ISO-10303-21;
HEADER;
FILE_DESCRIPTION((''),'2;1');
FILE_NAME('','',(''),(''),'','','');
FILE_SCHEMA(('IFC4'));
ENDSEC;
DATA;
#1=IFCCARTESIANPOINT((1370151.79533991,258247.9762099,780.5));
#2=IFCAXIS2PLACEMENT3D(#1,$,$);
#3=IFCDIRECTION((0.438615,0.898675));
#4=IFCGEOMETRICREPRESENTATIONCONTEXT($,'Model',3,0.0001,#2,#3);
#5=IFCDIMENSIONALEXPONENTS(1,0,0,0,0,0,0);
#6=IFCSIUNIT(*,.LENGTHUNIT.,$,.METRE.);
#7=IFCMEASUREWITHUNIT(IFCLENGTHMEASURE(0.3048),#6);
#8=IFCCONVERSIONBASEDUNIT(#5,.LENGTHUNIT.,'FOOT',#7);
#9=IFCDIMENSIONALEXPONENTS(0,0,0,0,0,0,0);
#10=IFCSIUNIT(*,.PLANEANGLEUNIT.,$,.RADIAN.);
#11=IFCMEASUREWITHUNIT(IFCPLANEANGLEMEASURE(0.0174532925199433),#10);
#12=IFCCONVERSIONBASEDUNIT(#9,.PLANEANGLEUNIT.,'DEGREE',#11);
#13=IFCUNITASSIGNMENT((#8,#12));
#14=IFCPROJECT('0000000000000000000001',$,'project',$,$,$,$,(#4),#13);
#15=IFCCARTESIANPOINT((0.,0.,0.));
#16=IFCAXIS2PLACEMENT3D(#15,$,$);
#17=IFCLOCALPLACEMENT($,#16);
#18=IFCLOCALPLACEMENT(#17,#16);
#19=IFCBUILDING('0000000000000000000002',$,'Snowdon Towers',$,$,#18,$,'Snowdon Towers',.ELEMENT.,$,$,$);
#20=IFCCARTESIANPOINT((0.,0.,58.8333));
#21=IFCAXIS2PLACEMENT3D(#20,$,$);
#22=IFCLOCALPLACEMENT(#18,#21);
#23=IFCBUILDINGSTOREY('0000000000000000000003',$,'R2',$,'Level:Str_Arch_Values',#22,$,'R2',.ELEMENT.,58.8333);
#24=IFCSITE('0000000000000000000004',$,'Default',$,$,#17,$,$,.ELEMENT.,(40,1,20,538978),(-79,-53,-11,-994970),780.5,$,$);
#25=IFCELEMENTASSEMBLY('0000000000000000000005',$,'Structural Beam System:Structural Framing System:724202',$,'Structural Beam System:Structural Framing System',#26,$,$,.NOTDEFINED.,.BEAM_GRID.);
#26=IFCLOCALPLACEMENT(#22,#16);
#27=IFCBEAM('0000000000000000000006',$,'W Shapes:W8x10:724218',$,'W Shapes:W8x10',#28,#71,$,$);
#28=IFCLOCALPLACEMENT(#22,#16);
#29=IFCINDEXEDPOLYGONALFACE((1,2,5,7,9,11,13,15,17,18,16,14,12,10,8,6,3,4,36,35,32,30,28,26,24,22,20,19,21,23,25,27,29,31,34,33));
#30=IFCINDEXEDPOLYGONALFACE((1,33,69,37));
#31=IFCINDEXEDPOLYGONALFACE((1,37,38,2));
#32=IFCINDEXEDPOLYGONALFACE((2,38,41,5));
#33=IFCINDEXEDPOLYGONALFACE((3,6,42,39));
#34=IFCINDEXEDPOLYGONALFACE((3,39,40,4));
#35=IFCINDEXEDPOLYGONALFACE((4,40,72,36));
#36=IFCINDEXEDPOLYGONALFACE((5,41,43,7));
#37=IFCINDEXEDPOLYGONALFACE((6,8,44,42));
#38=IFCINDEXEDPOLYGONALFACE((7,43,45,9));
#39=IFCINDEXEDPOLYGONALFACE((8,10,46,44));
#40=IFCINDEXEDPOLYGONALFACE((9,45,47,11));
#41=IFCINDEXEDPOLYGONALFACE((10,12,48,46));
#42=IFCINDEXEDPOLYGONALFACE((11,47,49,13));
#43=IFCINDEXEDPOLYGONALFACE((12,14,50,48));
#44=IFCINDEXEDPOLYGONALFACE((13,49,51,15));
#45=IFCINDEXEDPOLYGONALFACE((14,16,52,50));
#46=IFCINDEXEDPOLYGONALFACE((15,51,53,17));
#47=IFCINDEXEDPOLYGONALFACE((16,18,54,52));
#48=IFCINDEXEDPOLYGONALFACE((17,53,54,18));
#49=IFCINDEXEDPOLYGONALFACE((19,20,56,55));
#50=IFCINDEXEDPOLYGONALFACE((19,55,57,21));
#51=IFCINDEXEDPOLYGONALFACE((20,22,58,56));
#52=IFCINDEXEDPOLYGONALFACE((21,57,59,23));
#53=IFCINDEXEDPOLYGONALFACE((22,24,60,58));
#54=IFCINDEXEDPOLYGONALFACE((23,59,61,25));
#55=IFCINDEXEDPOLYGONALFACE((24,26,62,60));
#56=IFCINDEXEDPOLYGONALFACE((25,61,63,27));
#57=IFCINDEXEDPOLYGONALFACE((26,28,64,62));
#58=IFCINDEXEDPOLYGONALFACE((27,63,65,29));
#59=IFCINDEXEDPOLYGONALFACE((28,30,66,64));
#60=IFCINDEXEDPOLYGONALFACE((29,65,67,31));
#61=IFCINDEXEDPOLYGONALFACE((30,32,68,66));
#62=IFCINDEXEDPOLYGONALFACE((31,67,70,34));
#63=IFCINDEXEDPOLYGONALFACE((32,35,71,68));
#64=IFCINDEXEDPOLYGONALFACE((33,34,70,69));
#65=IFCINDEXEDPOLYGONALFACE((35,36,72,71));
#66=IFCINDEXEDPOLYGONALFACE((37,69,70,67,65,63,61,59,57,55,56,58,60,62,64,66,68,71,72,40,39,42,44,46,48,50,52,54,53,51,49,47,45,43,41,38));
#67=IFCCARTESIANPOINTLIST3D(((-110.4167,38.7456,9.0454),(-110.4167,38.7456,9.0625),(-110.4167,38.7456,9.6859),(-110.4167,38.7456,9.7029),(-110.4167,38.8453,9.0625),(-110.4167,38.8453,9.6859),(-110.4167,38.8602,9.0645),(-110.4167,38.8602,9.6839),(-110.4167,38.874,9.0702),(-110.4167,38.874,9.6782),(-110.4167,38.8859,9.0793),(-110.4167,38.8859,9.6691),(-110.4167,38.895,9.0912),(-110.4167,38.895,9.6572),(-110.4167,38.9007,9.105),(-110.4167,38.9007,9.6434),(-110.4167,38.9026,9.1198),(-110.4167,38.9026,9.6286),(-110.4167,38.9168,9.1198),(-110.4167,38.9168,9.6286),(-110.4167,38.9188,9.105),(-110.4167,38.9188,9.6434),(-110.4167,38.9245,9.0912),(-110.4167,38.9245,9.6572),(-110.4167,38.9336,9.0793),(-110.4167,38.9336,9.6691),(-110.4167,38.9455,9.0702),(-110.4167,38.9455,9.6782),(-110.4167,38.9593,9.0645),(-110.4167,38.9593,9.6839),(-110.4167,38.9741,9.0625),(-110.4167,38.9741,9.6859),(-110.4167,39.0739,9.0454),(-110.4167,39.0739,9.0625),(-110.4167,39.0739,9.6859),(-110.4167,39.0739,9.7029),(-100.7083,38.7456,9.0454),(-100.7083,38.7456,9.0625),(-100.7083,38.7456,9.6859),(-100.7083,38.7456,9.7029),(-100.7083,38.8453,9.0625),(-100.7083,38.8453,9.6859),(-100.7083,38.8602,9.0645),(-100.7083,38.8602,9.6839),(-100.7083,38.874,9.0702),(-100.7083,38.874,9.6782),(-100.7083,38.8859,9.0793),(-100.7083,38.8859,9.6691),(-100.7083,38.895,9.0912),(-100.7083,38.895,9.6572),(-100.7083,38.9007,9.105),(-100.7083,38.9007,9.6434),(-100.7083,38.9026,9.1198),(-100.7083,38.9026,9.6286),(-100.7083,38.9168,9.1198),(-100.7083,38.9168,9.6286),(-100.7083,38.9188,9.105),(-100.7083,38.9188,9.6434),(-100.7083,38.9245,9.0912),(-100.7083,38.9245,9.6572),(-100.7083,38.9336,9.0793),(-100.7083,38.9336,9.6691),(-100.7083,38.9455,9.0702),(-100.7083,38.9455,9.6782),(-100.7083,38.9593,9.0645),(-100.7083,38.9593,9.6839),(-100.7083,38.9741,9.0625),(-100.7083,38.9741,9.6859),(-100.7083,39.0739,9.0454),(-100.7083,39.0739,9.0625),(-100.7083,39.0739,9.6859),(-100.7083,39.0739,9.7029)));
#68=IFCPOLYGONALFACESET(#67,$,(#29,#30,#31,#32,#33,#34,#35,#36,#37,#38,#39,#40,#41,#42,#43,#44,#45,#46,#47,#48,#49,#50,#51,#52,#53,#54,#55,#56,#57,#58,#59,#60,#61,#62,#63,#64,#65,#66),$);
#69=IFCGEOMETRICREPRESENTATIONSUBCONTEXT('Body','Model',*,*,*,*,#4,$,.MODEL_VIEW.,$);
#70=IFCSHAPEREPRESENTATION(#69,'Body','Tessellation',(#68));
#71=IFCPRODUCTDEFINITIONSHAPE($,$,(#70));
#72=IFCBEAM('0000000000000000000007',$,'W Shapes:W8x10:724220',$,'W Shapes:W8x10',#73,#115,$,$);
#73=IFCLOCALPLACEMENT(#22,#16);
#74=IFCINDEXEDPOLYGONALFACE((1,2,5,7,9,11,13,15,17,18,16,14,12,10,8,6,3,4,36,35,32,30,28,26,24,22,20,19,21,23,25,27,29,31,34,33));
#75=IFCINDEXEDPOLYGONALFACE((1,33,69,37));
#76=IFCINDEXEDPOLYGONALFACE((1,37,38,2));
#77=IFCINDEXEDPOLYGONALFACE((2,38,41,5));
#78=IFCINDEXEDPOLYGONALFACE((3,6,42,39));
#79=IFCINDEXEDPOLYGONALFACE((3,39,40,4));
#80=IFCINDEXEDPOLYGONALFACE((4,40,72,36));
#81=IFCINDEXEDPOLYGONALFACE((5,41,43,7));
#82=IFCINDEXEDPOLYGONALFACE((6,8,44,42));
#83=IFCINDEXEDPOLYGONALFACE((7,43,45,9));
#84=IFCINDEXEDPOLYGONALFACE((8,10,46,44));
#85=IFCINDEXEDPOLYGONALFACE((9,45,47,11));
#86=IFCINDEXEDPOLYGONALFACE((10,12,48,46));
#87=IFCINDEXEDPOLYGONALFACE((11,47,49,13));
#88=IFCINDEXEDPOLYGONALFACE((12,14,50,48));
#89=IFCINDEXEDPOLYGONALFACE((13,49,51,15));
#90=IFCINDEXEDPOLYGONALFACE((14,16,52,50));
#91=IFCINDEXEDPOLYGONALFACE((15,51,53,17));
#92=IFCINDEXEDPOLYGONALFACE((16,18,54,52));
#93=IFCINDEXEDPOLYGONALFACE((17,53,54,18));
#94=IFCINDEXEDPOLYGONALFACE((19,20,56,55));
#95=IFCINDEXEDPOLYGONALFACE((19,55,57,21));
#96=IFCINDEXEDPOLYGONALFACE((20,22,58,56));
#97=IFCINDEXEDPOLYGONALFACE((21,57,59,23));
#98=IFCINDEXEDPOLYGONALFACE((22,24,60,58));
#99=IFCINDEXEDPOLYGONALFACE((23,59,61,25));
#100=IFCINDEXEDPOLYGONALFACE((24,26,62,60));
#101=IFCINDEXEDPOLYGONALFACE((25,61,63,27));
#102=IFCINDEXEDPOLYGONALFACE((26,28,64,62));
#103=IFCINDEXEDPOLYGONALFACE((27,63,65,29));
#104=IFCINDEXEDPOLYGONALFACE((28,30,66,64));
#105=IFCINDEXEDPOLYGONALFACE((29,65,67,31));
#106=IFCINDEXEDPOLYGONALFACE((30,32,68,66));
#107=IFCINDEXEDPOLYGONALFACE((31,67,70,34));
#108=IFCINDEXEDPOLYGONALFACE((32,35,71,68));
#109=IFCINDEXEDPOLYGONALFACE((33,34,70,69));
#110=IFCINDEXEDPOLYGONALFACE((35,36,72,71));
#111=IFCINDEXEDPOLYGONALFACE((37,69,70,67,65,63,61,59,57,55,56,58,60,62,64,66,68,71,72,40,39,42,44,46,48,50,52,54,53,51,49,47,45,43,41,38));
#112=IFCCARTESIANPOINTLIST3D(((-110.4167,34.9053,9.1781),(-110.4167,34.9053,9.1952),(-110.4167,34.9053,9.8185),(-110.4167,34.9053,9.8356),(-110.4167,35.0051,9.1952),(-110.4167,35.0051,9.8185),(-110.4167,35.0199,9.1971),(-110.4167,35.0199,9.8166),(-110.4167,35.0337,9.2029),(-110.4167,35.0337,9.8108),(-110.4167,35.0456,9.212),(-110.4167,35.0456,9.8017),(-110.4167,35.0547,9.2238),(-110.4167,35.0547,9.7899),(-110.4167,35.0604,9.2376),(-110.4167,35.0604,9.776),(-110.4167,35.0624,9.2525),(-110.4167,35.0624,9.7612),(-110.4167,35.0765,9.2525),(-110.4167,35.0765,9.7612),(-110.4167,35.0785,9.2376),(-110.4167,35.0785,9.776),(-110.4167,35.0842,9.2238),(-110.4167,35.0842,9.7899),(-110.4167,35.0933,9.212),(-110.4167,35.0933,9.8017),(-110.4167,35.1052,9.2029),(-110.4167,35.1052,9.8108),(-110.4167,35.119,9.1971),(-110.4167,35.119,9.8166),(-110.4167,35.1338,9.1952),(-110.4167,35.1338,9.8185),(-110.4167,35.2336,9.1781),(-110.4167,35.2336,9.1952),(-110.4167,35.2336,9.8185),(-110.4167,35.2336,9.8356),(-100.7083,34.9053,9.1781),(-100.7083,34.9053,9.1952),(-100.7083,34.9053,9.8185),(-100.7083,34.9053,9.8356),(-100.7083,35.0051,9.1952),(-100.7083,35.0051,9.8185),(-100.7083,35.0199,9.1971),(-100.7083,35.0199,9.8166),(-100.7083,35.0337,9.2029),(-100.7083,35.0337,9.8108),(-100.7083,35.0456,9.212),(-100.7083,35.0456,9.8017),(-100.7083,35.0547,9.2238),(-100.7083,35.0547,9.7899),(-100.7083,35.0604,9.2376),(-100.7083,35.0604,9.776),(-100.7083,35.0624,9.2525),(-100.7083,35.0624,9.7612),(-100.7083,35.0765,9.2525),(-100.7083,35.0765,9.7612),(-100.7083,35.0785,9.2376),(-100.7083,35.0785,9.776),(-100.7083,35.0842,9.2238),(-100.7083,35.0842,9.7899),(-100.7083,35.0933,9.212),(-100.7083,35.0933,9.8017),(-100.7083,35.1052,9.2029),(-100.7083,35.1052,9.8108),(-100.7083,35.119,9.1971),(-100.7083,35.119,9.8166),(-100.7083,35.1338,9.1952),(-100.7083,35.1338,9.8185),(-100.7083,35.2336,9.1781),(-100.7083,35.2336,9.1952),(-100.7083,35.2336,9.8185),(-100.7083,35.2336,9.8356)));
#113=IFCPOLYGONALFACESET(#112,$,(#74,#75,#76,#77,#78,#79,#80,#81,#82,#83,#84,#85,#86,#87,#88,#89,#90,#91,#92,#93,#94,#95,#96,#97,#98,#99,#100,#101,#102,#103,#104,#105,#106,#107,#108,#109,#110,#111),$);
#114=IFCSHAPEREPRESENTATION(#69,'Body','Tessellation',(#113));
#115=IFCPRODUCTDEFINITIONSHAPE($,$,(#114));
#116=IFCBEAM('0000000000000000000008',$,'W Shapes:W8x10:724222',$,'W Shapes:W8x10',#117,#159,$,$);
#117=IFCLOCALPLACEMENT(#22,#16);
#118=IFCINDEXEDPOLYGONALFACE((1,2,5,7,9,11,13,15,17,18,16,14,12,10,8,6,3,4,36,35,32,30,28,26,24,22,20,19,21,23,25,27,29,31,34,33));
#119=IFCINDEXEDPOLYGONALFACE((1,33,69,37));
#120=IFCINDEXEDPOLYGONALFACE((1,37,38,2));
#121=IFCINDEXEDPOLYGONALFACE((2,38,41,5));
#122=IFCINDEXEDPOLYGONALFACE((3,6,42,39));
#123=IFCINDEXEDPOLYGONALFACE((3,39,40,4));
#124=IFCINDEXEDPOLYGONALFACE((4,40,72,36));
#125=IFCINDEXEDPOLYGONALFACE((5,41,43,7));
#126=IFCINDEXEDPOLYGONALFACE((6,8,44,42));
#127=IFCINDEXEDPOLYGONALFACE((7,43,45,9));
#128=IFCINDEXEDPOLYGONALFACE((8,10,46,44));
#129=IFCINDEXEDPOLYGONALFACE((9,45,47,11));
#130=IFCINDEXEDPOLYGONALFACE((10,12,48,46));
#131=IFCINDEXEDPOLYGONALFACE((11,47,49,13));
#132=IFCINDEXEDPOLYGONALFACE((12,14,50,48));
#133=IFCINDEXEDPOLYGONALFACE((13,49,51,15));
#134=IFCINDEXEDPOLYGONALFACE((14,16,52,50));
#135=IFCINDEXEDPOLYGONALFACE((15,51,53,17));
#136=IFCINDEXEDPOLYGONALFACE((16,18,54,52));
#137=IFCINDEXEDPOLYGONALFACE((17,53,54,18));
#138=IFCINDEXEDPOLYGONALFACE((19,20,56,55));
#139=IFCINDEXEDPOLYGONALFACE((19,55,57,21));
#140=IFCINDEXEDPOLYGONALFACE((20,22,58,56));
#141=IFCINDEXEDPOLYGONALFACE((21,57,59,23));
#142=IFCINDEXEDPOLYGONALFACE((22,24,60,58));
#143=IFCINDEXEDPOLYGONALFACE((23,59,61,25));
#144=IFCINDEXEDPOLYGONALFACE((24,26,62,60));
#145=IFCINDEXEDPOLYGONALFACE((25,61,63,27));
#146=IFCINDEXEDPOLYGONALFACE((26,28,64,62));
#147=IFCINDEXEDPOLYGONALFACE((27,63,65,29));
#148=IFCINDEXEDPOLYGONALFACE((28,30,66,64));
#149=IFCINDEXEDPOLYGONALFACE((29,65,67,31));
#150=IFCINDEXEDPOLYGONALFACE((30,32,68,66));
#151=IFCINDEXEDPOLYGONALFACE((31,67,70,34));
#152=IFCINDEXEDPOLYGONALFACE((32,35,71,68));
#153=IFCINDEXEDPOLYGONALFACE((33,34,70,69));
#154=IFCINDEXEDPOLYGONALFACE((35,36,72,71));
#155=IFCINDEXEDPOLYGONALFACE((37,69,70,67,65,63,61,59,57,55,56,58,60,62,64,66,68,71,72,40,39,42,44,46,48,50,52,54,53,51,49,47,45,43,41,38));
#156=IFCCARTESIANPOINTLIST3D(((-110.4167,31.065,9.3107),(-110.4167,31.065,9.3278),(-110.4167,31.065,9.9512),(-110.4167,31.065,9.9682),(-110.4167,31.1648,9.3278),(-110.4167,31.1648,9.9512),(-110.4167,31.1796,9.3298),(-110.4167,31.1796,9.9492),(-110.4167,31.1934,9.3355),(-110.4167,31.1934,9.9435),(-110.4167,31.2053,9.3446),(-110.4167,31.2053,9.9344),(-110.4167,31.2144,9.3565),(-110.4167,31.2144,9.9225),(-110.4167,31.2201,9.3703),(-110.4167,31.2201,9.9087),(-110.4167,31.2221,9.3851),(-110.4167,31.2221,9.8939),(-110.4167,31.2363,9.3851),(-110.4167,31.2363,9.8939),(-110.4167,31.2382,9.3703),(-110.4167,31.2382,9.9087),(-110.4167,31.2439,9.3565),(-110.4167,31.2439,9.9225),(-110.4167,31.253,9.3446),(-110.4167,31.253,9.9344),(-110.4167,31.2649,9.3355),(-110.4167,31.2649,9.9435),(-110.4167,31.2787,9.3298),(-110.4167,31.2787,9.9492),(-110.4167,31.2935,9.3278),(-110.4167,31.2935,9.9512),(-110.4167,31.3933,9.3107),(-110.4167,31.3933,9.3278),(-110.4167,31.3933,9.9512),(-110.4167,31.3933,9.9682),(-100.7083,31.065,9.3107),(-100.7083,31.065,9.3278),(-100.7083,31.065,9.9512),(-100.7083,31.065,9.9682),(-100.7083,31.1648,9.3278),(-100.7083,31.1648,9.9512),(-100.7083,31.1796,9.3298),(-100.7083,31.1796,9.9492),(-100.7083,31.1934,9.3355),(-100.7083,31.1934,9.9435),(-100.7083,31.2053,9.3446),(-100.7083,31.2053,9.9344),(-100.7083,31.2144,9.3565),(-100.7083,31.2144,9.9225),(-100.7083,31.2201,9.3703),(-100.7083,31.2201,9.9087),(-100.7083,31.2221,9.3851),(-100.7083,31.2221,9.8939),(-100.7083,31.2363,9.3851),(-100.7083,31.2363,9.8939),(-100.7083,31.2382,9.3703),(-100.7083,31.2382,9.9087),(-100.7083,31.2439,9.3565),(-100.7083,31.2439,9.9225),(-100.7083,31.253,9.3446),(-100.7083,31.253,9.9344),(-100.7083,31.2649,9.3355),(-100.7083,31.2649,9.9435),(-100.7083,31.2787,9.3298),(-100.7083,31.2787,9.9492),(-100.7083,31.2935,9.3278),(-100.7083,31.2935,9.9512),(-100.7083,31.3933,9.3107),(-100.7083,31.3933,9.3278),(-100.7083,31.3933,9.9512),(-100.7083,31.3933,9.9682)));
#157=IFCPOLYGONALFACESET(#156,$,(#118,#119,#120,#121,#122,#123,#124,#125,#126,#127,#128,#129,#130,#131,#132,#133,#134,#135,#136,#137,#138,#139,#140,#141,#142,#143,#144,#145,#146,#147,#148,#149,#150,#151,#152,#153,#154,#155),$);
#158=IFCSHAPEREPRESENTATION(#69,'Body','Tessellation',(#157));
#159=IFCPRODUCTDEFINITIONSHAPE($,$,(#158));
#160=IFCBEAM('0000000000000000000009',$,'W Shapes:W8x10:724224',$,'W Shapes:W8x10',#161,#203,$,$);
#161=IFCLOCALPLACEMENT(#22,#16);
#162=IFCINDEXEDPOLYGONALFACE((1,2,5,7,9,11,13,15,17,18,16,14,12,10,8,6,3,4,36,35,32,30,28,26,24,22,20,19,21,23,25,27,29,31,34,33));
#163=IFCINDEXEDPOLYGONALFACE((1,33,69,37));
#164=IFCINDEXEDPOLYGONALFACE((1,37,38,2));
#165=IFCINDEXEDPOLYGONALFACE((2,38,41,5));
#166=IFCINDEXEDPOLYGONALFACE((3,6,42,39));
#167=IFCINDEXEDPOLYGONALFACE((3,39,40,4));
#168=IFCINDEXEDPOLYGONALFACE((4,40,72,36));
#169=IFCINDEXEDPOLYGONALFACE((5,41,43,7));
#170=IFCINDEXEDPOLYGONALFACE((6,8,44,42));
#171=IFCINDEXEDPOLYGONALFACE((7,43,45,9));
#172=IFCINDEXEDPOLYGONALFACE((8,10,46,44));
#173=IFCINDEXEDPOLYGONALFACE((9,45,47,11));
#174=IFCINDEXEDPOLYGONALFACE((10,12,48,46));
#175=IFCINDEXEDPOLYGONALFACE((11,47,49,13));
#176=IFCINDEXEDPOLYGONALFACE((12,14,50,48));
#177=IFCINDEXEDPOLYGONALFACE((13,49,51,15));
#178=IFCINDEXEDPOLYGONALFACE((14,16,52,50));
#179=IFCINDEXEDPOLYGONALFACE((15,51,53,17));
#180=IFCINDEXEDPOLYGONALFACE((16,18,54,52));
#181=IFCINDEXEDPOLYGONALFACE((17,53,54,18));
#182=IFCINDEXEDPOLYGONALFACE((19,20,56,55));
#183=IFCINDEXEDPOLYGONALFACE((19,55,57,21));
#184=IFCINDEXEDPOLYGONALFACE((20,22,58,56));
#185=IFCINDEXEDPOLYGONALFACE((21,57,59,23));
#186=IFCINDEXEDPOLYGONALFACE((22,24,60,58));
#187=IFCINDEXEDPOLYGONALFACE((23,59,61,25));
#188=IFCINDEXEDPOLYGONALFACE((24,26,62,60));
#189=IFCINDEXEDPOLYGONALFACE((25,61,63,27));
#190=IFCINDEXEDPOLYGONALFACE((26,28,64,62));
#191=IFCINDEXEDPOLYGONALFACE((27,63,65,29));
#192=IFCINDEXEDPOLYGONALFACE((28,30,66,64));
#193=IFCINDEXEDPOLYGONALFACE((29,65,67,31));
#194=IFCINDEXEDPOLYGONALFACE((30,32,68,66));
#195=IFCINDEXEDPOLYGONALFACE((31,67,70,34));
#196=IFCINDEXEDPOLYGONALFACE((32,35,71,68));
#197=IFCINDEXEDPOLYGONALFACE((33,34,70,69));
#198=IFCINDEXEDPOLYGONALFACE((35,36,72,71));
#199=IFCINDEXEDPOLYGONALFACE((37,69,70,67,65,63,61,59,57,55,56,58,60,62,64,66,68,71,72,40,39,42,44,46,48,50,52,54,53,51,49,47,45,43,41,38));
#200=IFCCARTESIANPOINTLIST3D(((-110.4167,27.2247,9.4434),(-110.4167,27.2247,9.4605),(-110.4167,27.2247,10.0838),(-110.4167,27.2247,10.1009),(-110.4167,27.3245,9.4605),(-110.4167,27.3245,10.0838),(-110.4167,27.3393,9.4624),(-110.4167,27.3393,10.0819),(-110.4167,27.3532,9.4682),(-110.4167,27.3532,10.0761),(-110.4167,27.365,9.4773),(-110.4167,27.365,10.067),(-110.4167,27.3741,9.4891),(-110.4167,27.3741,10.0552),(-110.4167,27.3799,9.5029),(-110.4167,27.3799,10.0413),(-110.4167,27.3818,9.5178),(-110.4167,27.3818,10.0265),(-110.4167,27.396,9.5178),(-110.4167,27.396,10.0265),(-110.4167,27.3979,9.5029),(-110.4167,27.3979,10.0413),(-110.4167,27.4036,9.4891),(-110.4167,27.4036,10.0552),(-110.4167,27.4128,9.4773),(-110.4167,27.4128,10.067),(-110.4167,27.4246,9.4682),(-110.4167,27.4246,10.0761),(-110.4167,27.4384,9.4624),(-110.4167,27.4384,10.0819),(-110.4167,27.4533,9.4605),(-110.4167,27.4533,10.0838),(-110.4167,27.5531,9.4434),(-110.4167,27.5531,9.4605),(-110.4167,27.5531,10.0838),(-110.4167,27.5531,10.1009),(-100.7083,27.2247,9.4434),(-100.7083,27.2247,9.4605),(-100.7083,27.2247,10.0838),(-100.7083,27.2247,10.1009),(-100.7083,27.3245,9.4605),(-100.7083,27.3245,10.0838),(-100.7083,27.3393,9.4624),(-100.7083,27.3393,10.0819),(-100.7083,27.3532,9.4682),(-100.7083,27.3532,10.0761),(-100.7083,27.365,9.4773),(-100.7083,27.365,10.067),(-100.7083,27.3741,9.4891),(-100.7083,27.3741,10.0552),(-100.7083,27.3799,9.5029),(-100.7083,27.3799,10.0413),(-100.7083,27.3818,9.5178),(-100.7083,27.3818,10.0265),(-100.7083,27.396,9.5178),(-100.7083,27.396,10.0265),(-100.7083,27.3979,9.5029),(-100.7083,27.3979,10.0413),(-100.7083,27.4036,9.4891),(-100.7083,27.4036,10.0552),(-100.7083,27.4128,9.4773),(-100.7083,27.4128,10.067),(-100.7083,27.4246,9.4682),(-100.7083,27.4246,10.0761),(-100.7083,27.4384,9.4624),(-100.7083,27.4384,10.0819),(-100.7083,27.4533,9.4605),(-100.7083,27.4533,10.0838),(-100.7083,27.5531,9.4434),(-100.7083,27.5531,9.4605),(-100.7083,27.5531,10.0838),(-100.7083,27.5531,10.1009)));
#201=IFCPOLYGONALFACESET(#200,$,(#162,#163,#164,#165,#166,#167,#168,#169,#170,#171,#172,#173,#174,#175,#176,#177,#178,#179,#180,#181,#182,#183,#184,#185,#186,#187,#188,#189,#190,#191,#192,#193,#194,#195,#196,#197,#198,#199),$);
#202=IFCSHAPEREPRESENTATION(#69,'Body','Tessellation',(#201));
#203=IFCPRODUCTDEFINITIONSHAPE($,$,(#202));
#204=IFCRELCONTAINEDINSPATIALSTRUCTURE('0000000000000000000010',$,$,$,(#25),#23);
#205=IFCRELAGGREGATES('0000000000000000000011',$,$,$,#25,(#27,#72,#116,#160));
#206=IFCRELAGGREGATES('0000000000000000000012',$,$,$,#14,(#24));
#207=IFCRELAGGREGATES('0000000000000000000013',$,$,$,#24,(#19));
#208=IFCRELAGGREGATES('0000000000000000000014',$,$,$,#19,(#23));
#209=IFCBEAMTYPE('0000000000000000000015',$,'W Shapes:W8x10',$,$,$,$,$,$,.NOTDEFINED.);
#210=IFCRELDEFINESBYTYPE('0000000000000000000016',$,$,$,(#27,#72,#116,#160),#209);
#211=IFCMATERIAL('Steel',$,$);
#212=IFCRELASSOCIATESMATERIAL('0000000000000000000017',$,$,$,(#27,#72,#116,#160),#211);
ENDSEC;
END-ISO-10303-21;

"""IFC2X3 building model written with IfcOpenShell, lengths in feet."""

from ifc_helpers import new_model, entity, si_unit, converted_unit, direction, frame, frame_2d, origin, place, context, subcontext, project, spatial, i_section, extrude, material, type_object, element, aggregate, save


model = new_model("IFC2X3")

# Units and contexts
model_context = context("Model", 3, precision=0.0001, world=frame((1370151.79533991, 258247.9762099, 780.5)), true_north=direction((0.438615, 0.898675)))
body_context = subcontext(model_context, "Body", "Model", "MODEL_VIEW")
ifc_project = project(units=[converted_unit("LENGTHUNIT", "FOOT", entity("IfcLengthMeasure", 0.3048), si_unit("LENGTHUNIT", "METRE"), dimensions=[1, 0, 0, 0, 0, 0, 0]), converted_unit("PLANEANGLEUNIT", "DEGREE", entity("IfcPlaneAngleMeasure", 0.0174532925199433), si_unit("PLANEANGLEUNIT", "RADIAN"), dimensions=[0, 0, 0, 0, 0, 0, 0])], contexts=[model_context])

# Site, building, storey
site_placement = place(None, origin())
site = spatial("IfcSite", under=ifc_project, at=site_placement, Name="Default", CompositionType="ELEMENT", RefLatitude=(40, 1, 20, 538978), RefLongitude=(-79, -53, -11, -994970), RefElevation=780.5)
building_placement = place(site_placement, origin())
building = spatial("IfcBuilding", under=site, at=building_placement, Name="Snowdon Towers", LongName="Snowdon Towers", CompositionType="ELEMENT")
storey_placement = place(building_placement, frame((0.0, 0.0, 58.8333)))
storey = spatial("IfcBuildingStorey", under=building, at=storey_placement, Name="R2", ObjectType="Level:Str_Arch_Values", LongName="R2", CompositionType="ELEMENT", Elevation=58.8333)

# Element assembly, beams
assembly_1_placement = place(storey_placement, origin())
assembly_1 = element("IfcElementAssembly", 1, at=assembly_1_placement, inside=storey, Name="Structural Beam System:Structural Framing System:724202", ObjectType="Structural Beam System:Structural Framing System", AssemblyPlace="NOTDEFINED", PredefinedType="BEAM_GRID")
ifc_material_1 = material(Name="Steel")
beam_type = type_object("IfcBeamType", Name="W Shapes:W8x10", PredefinedType="NOTDEFINED")
beam_1_placement = place(assembly_1_placement, frame((-110.5, 38.9097, 9.7029)))
beam_1 = element("IfcBeam", 2, at=beam_1_placement, type_object=beam_type, material=ifc_material_1, Name="W Shapes:W8x10:724218", ObjectType="W Shapes:W8x10", context=body_context, shape_type="SweptSolid", body=[
    extrude(i_section(OverallWidth=0.3283, OverallDepth=0.6575, WebThickness=0.0142, FlangeThickness=0.0171, FilletRadius=0.0573, at=frame_2d((0.0, 0.0), x_axis=(0.0, 1.0))), frame((0.0833, 0.0, -0.3288), z_axis=(1.0, 0.0, 0.0), x_axis=(0.0, 0.0, -1.0)), (0.0, 0.0, 1.0), 9.7083),
])
beam_2_placement = place(assembly_1_placement, frame((-110.5, 35.0694, 9.8356)))
beam_2 = element("IfcBeam", 3, at=beam_2_placement, type_object=beam_type, material=ifc_material_1, Name="W Shapes:W8x10:724220", ObjectType="W Shapes:W8x10", context=body_context, shape_type="SweptSolid", body=[
    extrude(i_section(OverallWidth=0.3283, OverallDepth=0.6575, WebThickness=0.0142, FlangeThickness=0.0171, FilletRadius=0.0573, at=frame_2d((0.0, 0.0), x_axis=(0.0, 1.0))), frame((0.0833, 0.0, -0.3288), z_axis=(1.0, 0.0, 0.0), x_axis=(0.0, 0.0, -1.0)), (0.0, 0.0, 1.0), 9.7083),
])
beam_3_placement = place(assembly_1_placement, frame((-110.5, 31.2292, 9.9682)))
beam_3 = element("IfcBeam", 4, at=beam_3_placement, type_object=beam_type, material=ifc_material_1, Name="W Shapes:W8x10:724222", ObjectType="W Shapes:W8x10", context=body_context, shape_type="SweptSolid", body=[
    extrude(i_section(OverallWidth=0.3283, OverallDepth=0.6575, WebThickness=0.0142, FlangeThickness=0.0171, FilletRadius=0.0573, at=frame_2d((0.0, 0.0), x_axis=(0.0, 1.0))), frame((0.0833, 0.0, -0.3288), z_axis=(1.0, 0.0, 0.0), x_axis=(0.0, 0.0, -1.0)), (0.0, 0.0, 1.0), 9.7083),
])
beam_4_placement = place(assembly_1_placement, frame((-110.5, 27.3889, 10.1009)))
beam_4 = element("IfcBeam", 5, at=beam_4_placement, type_object=beam_type, material=ifc_material_1, Name="W Shapes:W8x10:724224", ObjectType="W Shapes:W8x10", context=body_context, shape_type="SweptSolid", body=[
    extrude(i_section(OverallWidth=0.3283, OverallDepth=0.6575, WebThickness=0.0142, FlangeThickness=0.0171, FilletRadius=0.0573, at=frame_2d((0.0, 0.0), x_axis=(0.0, 1.0))), frame((0.0833, 0.0, -0.3288), z_axis=(1.0, 0.0, 0.0), x_axis=(0.0, 0.0, -1.0)), (0.0, 0.0, 1.0), 9.7083),
])
aggregate(assembly_1, [beam_1, beam_2, beam_3, beam_4])

save(model, "model.ifc")
